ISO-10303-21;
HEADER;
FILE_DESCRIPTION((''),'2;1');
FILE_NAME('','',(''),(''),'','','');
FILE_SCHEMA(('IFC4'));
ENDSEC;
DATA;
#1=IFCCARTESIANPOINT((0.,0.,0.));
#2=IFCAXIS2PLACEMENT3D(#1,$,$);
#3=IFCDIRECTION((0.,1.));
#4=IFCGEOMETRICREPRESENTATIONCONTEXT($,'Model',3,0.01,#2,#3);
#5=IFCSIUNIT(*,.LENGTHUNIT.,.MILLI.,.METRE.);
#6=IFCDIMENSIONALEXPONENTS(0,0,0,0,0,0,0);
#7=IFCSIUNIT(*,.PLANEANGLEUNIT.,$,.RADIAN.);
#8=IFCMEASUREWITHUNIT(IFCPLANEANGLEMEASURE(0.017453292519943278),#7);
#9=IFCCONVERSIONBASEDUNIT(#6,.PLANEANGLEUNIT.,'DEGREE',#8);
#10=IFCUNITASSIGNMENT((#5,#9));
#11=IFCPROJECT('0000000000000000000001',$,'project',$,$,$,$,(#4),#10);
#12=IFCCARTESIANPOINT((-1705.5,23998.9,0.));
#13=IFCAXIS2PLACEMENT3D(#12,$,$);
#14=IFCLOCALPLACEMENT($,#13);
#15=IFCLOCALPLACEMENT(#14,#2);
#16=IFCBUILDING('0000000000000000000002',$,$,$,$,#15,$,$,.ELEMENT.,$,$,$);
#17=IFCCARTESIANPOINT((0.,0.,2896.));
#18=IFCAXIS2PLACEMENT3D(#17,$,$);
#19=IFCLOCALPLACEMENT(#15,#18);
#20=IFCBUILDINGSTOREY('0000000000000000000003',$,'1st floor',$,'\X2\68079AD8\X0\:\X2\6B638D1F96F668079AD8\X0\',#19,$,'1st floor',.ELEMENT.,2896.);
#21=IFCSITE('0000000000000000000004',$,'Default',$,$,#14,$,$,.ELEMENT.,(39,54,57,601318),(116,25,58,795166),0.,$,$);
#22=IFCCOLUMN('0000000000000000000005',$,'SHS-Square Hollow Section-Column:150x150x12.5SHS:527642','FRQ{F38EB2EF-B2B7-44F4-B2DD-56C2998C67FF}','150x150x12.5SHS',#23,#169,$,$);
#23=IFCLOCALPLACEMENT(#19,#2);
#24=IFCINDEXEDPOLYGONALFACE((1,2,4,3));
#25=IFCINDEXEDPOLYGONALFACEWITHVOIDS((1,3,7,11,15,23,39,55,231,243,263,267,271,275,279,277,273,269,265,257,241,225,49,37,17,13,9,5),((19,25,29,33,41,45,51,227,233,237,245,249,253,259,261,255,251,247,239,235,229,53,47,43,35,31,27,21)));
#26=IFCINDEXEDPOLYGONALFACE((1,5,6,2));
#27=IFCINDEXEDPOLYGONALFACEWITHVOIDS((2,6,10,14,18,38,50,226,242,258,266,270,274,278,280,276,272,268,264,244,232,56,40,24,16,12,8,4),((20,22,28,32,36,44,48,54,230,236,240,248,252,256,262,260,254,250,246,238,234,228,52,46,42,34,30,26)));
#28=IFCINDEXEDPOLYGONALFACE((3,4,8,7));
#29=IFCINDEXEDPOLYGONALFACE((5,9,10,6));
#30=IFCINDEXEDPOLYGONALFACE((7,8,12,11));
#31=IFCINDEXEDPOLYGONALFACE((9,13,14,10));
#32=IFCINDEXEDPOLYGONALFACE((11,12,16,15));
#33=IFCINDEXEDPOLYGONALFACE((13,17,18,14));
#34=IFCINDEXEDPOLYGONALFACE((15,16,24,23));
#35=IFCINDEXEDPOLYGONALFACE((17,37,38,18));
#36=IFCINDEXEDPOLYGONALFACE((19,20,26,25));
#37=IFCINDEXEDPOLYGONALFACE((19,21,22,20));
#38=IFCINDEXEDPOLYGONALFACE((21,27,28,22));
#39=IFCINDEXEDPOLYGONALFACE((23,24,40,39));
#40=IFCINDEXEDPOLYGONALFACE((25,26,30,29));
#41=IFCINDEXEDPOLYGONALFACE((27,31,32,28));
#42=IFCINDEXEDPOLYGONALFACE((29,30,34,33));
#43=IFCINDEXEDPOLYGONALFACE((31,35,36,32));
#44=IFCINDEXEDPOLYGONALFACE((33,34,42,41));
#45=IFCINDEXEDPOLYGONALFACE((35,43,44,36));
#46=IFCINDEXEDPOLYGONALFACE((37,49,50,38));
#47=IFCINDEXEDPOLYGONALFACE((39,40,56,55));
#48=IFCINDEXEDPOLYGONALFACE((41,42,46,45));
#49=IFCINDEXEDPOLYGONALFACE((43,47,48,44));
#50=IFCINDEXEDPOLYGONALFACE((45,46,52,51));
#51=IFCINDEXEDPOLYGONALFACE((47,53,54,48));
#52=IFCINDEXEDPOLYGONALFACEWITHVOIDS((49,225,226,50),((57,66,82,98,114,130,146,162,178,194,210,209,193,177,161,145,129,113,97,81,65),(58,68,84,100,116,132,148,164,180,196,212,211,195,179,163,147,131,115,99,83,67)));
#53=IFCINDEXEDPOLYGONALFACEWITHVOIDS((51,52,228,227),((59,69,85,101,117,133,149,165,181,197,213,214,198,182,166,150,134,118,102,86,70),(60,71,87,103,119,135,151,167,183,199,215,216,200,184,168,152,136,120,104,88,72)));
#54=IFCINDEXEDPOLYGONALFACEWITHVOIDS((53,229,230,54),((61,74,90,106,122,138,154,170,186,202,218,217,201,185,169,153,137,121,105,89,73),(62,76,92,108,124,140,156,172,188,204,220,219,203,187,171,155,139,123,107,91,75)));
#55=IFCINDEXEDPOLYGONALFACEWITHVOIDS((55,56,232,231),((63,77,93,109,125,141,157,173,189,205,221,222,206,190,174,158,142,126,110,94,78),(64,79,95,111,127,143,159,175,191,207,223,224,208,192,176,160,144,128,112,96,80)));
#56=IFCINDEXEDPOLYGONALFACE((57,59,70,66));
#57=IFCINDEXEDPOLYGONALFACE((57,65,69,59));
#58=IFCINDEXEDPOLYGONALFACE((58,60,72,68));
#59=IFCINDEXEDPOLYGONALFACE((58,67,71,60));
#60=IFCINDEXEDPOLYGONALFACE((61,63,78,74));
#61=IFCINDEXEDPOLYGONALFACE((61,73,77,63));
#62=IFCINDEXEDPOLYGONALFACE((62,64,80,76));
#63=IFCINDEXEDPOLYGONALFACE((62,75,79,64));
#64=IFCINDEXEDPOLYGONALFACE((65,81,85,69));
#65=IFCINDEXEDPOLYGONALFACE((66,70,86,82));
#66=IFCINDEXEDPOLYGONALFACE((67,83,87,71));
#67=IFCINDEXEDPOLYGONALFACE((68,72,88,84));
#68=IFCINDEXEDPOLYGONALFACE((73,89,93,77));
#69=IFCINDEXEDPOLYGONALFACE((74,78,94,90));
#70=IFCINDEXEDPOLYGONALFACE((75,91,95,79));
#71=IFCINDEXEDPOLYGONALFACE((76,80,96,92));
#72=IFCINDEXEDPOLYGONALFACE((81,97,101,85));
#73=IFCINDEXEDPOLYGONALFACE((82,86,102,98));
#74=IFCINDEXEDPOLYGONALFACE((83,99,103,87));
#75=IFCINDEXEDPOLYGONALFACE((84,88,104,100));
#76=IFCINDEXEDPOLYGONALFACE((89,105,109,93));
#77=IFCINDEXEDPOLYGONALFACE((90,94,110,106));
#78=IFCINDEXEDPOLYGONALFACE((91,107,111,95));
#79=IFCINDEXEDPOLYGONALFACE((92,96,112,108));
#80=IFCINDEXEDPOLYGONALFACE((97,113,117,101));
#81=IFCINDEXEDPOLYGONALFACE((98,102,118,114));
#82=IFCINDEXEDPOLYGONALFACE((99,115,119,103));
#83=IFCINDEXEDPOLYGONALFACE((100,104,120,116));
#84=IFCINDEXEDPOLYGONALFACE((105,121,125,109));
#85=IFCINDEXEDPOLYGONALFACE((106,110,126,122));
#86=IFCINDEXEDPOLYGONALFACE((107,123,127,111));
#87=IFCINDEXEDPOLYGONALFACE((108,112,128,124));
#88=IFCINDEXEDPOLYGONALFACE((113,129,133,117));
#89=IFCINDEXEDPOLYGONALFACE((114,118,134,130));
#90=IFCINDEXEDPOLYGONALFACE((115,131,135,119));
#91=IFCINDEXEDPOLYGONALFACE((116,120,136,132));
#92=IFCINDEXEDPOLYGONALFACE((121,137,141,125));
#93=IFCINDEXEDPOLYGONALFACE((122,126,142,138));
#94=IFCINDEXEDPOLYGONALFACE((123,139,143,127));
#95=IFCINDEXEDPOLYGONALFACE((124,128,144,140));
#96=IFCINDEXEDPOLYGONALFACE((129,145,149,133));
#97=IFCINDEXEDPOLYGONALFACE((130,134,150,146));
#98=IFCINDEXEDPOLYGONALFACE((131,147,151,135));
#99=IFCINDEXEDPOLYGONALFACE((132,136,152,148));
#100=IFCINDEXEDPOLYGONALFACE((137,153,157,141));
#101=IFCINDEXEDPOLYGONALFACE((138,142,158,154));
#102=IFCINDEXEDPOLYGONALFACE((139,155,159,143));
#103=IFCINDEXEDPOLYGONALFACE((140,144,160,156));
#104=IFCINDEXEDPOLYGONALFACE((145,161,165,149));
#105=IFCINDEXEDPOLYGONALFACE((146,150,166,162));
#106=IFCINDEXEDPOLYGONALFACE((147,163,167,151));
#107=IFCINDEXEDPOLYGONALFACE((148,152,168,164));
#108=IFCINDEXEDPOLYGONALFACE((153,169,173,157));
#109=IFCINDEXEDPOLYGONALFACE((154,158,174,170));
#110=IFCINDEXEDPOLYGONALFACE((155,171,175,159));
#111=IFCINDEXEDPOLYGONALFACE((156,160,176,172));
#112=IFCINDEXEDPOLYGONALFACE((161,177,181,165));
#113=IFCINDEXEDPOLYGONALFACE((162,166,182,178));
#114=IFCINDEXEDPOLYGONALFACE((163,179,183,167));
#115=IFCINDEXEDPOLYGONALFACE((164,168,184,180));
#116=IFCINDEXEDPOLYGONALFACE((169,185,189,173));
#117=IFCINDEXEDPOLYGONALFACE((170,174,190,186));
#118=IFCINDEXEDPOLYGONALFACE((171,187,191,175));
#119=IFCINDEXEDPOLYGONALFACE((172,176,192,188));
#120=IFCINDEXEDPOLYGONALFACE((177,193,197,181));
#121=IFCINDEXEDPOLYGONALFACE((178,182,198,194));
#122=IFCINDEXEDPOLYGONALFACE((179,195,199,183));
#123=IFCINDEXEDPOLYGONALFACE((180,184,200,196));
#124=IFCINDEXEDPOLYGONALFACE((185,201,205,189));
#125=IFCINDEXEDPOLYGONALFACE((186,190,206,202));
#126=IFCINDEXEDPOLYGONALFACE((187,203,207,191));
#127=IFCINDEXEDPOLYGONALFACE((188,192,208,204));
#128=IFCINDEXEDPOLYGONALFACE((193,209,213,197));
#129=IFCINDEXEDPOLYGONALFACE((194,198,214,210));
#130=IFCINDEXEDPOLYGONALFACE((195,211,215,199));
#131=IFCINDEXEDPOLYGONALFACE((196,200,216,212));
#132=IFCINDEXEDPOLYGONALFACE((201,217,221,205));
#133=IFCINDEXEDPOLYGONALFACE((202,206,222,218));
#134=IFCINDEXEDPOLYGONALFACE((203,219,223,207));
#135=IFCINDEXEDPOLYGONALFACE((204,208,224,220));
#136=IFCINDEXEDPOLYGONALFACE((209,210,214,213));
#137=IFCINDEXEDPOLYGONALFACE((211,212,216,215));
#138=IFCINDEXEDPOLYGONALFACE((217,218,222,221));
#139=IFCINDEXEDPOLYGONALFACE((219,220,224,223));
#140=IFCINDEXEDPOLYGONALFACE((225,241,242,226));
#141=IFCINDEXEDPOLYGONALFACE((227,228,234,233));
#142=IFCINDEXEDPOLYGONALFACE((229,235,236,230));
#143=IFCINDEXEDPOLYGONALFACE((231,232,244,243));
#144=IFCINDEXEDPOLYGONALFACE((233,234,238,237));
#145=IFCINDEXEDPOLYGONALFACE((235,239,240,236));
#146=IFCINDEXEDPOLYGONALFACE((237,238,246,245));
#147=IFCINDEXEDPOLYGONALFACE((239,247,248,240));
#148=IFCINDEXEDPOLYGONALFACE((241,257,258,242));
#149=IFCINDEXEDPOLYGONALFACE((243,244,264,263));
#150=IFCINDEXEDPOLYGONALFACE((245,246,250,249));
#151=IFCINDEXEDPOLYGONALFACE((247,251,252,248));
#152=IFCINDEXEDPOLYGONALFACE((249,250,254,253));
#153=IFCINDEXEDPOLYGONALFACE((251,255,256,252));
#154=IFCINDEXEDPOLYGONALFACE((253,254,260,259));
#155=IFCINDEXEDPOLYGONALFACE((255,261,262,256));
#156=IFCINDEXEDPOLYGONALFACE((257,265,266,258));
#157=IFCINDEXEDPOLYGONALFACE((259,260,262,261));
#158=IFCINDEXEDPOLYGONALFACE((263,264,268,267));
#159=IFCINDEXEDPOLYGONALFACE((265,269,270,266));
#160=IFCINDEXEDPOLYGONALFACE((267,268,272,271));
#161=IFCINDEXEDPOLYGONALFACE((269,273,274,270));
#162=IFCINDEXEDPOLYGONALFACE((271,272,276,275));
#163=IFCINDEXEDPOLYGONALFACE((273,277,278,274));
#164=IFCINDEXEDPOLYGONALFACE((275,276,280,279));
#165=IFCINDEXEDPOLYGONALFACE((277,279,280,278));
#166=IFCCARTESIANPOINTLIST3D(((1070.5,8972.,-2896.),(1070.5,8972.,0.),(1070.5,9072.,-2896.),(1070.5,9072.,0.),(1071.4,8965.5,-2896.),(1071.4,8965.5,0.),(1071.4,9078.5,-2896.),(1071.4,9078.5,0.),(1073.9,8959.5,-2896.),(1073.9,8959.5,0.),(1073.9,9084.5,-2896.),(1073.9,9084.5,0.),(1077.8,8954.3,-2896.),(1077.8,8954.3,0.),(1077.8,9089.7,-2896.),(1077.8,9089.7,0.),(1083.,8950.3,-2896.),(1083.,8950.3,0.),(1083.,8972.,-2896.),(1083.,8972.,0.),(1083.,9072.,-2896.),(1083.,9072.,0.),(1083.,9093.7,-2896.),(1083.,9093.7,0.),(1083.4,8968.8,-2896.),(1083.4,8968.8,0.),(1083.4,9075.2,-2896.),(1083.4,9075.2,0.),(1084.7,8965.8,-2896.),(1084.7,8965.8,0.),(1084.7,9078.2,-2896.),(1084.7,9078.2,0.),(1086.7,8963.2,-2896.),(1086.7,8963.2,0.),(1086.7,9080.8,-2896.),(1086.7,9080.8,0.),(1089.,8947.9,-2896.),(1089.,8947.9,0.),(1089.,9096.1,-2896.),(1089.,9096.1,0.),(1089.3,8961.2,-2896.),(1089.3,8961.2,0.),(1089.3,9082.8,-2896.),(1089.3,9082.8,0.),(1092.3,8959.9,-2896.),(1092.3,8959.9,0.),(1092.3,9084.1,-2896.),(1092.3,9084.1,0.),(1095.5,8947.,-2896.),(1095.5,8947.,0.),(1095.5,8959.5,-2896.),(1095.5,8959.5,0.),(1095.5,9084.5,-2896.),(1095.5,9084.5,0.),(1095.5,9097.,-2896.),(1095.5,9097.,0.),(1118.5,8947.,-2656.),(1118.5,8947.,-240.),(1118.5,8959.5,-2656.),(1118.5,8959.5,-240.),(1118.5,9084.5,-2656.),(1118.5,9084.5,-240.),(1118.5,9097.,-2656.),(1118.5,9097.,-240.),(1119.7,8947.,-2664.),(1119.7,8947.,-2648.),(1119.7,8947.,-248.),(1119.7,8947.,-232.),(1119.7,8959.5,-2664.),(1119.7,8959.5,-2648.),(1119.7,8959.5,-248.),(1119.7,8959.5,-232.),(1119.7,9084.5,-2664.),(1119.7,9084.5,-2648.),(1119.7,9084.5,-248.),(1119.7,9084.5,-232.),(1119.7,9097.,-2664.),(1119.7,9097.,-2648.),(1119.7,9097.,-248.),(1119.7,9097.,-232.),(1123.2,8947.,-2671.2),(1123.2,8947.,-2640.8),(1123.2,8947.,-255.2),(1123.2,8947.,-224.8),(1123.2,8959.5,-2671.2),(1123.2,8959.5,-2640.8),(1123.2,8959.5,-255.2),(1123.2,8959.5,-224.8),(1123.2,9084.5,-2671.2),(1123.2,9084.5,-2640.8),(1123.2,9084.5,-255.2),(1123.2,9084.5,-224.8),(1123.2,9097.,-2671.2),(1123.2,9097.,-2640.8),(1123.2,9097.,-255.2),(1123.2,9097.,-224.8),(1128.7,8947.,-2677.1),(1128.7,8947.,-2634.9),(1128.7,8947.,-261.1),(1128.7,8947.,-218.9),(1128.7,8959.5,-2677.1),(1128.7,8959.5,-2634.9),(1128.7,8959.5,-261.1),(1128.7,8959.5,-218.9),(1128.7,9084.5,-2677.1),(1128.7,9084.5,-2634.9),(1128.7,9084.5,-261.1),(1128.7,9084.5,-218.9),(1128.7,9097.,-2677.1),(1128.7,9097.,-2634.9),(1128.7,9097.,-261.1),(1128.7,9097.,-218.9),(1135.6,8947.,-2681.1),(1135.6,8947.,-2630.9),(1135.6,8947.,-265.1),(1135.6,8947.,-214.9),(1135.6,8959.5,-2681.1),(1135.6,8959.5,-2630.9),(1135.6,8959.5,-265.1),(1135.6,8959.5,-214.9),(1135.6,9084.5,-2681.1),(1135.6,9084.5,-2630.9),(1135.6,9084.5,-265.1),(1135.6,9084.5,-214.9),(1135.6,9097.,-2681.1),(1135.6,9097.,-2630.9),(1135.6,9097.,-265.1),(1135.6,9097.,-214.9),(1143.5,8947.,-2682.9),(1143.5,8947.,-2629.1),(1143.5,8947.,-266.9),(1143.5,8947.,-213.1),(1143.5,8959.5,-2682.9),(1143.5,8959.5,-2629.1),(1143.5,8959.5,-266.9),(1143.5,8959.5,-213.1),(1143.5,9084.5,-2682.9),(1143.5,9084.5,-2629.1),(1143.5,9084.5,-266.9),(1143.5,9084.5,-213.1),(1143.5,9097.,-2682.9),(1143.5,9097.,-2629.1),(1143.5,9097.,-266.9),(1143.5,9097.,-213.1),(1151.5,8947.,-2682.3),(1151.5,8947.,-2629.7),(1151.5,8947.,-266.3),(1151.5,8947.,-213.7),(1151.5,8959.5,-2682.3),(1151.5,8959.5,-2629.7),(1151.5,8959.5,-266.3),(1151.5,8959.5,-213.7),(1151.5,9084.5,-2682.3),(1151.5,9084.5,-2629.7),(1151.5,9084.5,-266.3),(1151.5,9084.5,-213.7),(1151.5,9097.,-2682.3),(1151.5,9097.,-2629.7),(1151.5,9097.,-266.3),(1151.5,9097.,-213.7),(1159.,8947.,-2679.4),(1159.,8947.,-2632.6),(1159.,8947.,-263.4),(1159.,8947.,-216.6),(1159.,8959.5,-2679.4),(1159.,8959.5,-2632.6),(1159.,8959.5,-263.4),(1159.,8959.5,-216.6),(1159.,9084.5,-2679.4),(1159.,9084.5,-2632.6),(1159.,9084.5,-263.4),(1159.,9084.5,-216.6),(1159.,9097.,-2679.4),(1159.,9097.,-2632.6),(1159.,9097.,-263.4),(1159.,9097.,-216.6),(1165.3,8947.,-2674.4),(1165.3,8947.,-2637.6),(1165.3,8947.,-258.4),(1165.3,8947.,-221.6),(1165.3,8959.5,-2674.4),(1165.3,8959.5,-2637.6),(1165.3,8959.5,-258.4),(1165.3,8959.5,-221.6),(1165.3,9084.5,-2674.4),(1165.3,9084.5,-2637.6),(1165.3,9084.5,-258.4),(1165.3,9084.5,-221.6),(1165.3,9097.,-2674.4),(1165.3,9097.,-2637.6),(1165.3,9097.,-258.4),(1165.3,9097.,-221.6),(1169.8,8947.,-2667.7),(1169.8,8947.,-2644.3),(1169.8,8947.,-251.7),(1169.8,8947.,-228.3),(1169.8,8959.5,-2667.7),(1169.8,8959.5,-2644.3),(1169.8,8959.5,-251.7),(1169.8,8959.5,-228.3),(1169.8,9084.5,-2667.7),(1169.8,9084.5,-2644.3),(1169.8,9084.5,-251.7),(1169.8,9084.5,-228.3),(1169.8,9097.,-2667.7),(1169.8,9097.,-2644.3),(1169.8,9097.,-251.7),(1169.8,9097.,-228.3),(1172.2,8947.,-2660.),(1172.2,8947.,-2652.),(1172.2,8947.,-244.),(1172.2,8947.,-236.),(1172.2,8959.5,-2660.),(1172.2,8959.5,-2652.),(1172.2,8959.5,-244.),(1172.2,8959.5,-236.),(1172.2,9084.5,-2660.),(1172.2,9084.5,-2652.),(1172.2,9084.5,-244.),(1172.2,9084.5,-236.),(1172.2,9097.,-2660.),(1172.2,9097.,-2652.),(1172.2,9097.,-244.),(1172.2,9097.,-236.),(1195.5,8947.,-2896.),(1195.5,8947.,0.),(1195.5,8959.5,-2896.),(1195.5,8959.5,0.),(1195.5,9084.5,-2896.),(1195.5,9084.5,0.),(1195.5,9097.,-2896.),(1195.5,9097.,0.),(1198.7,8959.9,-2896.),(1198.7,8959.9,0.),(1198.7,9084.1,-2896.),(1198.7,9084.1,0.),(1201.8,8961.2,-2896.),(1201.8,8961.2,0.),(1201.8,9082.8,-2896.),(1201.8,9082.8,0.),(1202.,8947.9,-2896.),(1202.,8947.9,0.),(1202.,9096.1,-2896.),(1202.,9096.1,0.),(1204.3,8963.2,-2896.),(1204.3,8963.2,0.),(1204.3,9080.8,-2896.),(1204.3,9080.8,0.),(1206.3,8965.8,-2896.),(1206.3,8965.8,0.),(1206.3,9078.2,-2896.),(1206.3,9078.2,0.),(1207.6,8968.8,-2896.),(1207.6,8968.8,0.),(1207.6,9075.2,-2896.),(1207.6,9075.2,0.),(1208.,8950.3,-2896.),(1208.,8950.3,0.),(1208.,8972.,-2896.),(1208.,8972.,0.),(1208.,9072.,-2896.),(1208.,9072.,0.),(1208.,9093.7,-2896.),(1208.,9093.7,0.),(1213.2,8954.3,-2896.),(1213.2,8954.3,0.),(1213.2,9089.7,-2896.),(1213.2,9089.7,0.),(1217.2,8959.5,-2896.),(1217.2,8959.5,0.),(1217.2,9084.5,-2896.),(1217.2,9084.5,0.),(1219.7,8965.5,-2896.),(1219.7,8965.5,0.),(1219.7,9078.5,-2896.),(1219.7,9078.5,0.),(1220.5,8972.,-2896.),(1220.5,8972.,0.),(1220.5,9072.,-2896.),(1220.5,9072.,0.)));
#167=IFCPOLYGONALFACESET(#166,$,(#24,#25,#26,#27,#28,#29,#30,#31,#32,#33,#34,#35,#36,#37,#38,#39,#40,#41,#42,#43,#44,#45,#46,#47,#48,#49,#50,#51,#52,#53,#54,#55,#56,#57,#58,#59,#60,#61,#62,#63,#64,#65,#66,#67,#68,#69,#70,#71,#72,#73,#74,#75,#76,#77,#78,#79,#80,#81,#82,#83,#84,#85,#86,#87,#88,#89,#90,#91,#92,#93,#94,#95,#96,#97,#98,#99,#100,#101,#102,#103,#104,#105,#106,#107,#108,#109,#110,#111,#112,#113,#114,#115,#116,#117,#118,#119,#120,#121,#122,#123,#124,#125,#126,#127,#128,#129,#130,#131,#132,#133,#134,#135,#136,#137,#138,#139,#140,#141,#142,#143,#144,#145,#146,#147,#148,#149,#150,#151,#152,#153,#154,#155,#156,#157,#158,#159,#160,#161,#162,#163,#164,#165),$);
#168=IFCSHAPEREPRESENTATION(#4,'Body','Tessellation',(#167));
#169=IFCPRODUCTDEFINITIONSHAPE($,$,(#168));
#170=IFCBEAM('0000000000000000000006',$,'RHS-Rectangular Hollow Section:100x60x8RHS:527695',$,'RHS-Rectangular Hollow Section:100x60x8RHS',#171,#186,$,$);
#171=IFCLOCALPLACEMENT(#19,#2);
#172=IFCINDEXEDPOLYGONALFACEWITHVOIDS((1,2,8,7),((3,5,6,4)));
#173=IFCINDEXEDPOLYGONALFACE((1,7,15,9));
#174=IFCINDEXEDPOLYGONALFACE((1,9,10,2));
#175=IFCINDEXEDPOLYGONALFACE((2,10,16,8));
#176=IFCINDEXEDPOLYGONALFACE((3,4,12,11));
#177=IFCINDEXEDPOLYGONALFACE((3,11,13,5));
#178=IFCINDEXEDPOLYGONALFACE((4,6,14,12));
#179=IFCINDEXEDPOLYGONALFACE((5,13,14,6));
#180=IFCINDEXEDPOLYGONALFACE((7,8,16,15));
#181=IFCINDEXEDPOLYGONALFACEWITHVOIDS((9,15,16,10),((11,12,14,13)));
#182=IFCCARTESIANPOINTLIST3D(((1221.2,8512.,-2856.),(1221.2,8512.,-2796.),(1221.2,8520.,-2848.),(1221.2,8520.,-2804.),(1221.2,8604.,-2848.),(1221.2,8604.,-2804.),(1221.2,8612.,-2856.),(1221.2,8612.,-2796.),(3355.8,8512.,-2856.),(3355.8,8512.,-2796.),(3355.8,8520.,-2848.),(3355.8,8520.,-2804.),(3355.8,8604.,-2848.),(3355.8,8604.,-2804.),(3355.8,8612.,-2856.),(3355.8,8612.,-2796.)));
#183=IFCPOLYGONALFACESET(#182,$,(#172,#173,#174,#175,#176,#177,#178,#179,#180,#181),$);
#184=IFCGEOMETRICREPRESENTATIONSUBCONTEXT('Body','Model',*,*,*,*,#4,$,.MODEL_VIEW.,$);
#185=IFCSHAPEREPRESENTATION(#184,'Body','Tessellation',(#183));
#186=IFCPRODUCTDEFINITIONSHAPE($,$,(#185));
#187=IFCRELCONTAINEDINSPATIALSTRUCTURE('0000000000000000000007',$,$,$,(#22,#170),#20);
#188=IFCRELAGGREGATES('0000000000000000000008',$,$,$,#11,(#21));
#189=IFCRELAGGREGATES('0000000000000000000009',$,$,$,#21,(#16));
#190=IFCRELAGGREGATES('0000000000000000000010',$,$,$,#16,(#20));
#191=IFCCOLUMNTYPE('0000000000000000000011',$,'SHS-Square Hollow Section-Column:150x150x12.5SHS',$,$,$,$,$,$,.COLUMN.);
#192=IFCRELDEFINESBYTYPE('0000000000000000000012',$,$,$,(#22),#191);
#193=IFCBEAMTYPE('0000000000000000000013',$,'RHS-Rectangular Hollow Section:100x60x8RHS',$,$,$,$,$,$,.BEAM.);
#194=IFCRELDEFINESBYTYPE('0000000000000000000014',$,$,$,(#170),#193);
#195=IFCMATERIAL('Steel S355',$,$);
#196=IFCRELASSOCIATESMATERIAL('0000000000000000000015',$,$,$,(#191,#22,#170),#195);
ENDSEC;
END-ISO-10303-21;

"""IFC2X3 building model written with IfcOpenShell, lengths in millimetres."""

from ifc_helpers import new_model, entity, si_unit, converted_unit, direction, frame, frame_2d, origin, origin_2d, place, context, subcontext, project, spatial, circle_curve, rectangle, hollow_rectangle, outline, extrude, boolean, material, type_object, element, save


model = new_model("IFC2X3")

# Units and contexts
model_context = context("Model", 3, precision=0.01, world=origin(), true_north=direction((0.0, 1.0)))
body_context = subcontext(model_context, "Body", "Model", "MODEL_VIEW")
ifc_project = project(units=[si_unit("LENGTHUNIT", "METRE", prefix="MILLI"), converted_unit("PLANEANGLEUNIT", "DEGREE", entity("IfcPlaneAngleMeasure", 0.017453292519943278), si_unit("PLANEANGLEUNIT", "RADIAN"), dimensions=[0, 0, 0, 0, 0, 0, 0])], contexts=[model_context])

# Site, building, storey
site_placement = place(None, frame((-1705.5, 23998.9, 0.0)))
site = spatial("IfcSite", under=ifc_project, at=site_placement, Name="Default", CompositionType="ELEMENT", RefLatitude=(39, 54, 57, 601318), RefLongitude=(116, 25, 58, 795166), RefElevation=0.0)
building_placement = place(site_placement, origin())
building = spatial("IfcBuilding", under=site, at=building_placement, CompositionType="ELEMENT")
storey_placement = place(building_placement, frame((0.0, 0.0, 2896.0)))
storey = spatial("IfcBuildingStorey", under=building, at=storey_placement, Name="1st floor", ObjectType="标高:正负零标高", LongName="1st floor", CompositionType="ELEMENT", Elevation=2896.0)

# Shared definitions
ifc_material_1 = material(Name="Steel S355")

# Column, openings
column_type_1 = type_object("IfcColumnType", Name="SHS-Square Hollow Section-Column:150x150x12.5SHS", PredefinedType="COLUMN", material=ifc_material_1)
column_1_placement = place(storey_placement, frame((1145.5, 9022.0, 0.0), z_axis=(0.0, 0.0, 1.0), x_axis=(0.0, -1.0, 0.0)))
column_1 = element("IfcColumn", 1, at=column_1_placement, inside=storey, type_object=column_type_1, material=ifc_material_1, Name="SHS-Square Hollow Section-Column:150x150x12.5SHS:527642", Description="FRQ{F38EB2EF-B2B7-44F4-B2DD-56C2998C67FF}", ObjectType="150x150x12.5SHS", context=model_context, shape_type="SweptSolid", body=[
    extrude(hollow_rectangle(XDim=150.0, YDim=150.0, WallThickness=12.5, InnerFilletRadius=12.5, OuterFilletRadius=25.0, at=origin_2d()), origin(), (0.0, 0.0, -1.0), 2896.0),
])
opening_1_placement = place(column_1_placement, frame((175.1, 0.0, -2896.0), z_axis=(-1.0, 0.0, 0.0), x_axis=(0.0, -1.0, 0.0)))
element("IfcOpeningElement", 2, at=opening_1_placement, cuts=column_1, ObjectType="Opening", context=model_context, shape_type="SweptSolid", body=[
    extrude(outline(circle_curve(frame_2d((0.0, 240.0), x_axis=(1.0, 0.0)), 27.0)), origin(), (0.0, 0.0, 1.0), 350.2),
])
opening_2_placement = place(column_1_placement, frame((175.1, 0.0, 0.0), z_axis=(-1.0, 0.0, 0.0), x_axis=(0.0, -1.0, 0.0)))
element("IfcOpeningElement", 3, at=opening_2_placement, cuts=column_1, ObjectType="Opening", context=model_context, shape_type="SweptSolid", body=[
    extrude(outline(circle_curve(frame_2d((0.0, -240.0), x_axis=(1.0, 0.0)), 27.0)), origin(), (0.0, 0.0, 1.0), 350.2),
])

# Beam
beam_type_1 = type_object("IfcBeamType", Name="RHS-Rectangular Hollow Section:100x60x8RHS", PredefinedType="BEAM")
beam_1_placement = place(storey_placement, frame((1221.2, 8612.0, -2826.0)))
element("IfcBeam", 4, at=beam_1_placement, inside=storey, type_object=beam_type_1, material=ifc_material_1, Name="RHS-Rectangular Hollow Section:100x60x8RHS:527695", ObjectType="RHS-Rectangular Hollow Section:100x60x8RHS", context=body_context, shape_type="SweptSolid", body=[
    boolean("DIFFERENCE", extrude(rectangle(XDim=60.0, YDim=100.0, at=frame_2d((0.0, 0.0), x_axis=(1.0, 0.0))), frame((0.0, -50.0, 0.0), z_axis=(1.0, 0.0, 0.0), x_axis=(0.0, 0.0, -1.0)), (0.0, 0.0, 1.0), 2134.6), extrude(rectangle(XDim=44.0, YDim=84.0, at=frame_2d((0.0, 0.0), x_axis=(0.0, 1.0))), frame((2134.6, -50.0, 0.0), z_axis=(-1.0, 0.0, 0.0), x_axis=(0.0, 1.0, 0.0)), (0.0, 0.0, 1.0), 2134.6)),
])

save(model, "model.ifc")
